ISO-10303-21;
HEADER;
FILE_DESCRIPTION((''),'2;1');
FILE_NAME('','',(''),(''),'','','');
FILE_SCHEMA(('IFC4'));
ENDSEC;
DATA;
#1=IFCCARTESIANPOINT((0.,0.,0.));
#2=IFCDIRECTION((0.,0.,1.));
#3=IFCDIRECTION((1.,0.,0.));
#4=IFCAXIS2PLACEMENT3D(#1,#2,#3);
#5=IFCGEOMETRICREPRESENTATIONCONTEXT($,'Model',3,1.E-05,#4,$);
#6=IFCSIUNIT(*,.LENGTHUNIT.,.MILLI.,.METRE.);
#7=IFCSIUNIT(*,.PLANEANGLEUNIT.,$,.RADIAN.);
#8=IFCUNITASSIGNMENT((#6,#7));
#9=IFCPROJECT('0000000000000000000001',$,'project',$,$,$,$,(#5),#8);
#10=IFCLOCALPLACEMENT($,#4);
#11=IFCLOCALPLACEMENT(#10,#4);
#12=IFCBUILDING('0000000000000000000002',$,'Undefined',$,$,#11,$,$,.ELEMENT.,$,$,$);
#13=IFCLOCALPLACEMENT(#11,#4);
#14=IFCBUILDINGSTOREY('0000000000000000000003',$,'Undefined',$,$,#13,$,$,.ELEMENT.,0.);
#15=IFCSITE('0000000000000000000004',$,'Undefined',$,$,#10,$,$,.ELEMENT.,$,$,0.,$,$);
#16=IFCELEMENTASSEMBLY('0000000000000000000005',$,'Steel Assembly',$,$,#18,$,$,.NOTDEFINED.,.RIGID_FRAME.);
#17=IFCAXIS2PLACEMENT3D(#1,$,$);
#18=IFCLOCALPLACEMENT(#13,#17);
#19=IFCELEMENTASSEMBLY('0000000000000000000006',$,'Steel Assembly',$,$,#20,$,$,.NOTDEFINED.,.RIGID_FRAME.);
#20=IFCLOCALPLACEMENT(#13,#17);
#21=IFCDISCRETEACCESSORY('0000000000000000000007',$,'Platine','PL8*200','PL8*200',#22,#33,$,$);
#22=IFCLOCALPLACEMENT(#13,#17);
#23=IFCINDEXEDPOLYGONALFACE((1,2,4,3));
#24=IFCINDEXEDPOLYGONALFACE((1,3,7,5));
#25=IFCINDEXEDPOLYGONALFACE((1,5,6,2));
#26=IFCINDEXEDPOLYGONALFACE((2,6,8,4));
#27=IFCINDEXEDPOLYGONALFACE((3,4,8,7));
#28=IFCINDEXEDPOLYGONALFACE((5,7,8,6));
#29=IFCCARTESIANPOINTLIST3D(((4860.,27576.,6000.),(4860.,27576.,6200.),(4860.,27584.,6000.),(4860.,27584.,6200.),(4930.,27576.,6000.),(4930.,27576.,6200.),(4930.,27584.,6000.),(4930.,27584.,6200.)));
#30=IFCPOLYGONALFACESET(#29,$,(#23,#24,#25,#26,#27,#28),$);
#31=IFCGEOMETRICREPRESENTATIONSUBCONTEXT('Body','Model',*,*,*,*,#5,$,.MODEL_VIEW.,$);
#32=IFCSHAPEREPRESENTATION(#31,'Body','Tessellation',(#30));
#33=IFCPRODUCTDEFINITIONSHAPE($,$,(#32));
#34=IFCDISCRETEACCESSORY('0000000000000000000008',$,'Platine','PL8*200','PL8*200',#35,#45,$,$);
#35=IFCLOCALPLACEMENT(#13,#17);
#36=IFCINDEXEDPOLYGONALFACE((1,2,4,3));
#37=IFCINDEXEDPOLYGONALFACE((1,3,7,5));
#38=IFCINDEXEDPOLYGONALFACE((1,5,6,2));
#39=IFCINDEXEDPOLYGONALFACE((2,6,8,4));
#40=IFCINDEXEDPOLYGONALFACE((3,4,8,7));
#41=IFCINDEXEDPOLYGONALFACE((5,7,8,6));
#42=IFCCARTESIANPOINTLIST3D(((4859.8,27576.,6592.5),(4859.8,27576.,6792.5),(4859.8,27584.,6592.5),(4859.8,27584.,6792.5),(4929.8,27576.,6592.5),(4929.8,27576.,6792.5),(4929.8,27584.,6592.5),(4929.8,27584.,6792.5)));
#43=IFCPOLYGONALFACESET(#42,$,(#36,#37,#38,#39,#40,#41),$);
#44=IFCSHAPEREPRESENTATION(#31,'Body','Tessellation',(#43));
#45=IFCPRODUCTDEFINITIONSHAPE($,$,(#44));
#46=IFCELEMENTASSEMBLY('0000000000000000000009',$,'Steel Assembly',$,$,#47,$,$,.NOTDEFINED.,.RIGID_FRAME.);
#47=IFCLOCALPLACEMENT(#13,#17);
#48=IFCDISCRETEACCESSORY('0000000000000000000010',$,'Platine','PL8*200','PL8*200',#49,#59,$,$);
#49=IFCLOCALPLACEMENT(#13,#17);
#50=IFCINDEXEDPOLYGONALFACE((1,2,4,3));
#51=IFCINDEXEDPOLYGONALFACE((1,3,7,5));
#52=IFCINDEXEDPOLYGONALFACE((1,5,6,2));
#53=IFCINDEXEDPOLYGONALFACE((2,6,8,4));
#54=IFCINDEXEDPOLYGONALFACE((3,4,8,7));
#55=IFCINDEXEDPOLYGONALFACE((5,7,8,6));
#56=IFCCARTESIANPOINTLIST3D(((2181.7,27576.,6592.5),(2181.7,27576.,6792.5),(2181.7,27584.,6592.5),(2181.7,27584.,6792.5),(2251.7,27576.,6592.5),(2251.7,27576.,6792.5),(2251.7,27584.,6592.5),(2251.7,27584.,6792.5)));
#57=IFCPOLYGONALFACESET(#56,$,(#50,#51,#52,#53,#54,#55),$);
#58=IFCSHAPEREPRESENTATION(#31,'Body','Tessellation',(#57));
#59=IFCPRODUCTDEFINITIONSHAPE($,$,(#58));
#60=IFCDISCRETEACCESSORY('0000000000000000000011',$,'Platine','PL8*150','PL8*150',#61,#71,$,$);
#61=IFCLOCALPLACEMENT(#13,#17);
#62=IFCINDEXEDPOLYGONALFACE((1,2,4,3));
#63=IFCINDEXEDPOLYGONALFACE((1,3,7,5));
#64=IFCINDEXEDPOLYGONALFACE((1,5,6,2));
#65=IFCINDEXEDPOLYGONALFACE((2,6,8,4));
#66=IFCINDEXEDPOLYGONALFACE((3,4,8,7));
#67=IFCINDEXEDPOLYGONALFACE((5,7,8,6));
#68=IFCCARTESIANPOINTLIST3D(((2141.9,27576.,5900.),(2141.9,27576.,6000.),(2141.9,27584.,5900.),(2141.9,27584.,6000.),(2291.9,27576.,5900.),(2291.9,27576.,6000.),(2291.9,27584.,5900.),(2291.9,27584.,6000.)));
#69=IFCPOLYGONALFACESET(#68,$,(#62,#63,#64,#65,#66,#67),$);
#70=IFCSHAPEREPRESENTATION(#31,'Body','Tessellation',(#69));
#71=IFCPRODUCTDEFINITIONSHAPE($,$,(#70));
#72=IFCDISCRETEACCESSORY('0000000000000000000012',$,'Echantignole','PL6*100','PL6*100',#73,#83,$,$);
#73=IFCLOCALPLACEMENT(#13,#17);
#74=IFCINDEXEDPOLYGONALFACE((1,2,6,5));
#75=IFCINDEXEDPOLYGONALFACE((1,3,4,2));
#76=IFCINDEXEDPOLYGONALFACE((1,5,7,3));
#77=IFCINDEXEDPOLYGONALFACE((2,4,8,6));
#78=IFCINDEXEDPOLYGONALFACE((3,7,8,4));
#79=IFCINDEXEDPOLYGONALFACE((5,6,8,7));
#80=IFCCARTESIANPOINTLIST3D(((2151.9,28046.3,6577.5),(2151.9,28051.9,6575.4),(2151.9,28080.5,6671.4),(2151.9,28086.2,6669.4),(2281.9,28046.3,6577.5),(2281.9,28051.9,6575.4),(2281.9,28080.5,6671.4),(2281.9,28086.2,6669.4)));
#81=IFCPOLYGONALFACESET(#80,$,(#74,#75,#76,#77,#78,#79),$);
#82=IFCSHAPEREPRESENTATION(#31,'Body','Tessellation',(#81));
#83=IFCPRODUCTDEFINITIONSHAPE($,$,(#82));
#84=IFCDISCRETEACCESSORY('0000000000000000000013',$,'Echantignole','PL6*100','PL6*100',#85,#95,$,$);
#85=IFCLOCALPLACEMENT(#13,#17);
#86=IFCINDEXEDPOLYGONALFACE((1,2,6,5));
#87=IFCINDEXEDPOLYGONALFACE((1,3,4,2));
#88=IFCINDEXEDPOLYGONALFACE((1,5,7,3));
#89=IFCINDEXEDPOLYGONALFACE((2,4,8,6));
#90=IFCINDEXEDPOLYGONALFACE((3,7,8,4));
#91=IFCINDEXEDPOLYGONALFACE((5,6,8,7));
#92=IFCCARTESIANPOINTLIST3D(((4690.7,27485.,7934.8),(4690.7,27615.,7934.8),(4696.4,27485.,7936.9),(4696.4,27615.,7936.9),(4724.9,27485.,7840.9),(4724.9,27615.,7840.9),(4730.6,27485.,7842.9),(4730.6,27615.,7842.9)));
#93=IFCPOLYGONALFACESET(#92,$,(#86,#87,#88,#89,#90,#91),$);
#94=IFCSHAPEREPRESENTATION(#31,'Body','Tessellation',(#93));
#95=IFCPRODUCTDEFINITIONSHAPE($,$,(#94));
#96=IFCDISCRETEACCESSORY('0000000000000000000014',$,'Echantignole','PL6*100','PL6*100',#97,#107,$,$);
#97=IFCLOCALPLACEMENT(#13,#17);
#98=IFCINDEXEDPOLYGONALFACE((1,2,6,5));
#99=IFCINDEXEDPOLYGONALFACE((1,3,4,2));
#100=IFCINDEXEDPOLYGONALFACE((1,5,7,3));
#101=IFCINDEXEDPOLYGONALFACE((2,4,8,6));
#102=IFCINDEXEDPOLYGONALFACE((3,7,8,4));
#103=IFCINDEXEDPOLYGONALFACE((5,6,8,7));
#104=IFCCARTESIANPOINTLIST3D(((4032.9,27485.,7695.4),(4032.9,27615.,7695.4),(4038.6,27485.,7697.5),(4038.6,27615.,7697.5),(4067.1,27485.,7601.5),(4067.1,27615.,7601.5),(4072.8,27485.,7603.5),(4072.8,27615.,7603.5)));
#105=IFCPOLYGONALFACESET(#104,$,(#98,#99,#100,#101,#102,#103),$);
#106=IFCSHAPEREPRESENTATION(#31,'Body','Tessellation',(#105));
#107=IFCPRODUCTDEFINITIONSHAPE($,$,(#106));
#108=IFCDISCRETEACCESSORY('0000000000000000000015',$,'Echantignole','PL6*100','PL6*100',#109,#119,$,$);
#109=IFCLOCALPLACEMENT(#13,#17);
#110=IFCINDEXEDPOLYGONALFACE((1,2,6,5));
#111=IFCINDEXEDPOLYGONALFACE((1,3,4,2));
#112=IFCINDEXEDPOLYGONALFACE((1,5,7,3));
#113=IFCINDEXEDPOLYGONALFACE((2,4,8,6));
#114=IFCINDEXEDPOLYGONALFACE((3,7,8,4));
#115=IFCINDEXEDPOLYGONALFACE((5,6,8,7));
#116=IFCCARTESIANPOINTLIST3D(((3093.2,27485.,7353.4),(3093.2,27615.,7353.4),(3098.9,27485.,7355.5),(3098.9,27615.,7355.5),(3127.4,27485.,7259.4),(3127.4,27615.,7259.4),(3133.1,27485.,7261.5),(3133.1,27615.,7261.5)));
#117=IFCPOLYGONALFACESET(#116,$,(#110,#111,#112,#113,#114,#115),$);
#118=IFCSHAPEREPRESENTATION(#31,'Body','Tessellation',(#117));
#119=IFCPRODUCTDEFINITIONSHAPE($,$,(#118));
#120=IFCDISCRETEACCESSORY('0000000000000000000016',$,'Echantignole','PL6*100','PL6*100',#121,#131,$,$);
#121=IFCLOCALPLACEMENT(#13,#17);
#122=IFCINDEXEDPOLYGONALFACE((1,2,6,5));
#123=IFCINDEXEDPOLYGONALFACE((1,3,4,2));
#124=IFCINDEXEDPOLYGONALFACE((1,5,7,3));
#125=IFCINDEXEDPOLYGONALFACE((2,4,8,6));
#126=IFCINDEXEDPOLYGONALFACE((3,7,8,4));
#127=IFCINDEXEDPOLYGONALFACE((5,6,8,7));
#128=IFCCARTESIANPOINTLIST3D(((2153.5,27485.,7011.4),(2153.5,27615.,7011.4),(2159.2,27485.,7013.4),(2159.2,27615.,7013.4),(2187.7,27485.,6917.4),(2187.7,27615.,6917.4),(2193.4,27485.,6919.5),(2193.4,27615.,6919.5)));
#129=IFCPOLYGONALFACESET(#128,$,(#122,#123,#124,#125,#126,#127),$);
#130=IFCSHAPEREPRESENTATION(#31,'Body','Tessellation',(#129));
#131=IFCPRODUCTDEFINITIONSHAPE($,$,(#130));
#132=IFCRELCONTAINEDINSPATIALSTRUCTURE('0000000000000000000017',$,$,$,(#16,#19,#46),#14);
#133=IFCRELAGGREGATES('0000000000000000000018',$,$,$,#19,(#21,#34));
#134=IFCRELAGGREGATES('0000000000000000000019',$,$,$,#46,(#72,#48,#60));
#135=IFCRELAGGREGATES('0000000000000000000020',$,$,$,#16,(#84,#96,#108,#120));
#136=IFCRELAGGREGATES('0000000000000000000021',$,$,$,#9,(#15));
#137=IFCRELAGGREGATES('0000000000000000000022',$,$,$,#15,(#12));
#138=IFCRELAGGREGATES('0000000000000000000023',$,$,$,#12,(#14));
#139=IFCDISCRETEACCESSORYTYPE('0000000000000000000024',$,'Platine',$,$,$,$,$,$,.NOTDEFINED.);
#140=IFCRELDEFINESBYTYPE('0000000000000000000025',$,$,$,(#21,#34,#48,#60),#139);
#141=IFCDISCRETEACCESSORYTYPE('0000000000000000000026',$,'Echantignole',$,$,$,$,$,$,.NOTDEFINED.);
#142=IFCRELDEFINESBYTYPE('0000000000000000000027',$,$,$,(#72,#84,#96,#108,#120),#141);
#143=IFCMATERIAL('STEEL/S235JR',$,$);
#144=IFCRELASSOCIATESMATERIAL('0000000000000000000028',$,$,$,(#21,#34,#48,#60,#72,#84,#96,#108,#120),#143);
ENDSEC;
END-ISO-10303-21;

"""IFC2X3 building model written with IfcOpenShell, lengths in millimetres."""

from ifc_helpers import new_model, si_unit, frame, origin_with_axes, place, context, subcontext, project, spatial, polyline, outline, extrude, material, type_object, element, aggregate, save


model = new_model("IFC2X3")

# Units and contexts
model_context = context("Model", 3, precision=1e-05, world=origin_with_axes())
body_context = subcontext(model_context, "Body", "Model", "MODEL_VIEW")
ifc_project = project(units=[si_unit("LENGTHUNIT", "METRE", prefix="MILLI"), si_unit("PLANEANGLEUNIT", "RADIAN")], contexts=[model_context])

# Site, building, storey
site_placement = place(None, origin_with_axes())
site = spatial("IfcSite", under=ifc_project, at=site_placement, Name="Undefined", CompositionType="ELEMENT", RefElevation=0.0)
building_placement = place(site_placement, origin_with_axes())
building = spatial("IfcBuilding", under=site, at=building_placement, Name="Undefined", CompositionType="ELEMENT")
storey_placement = place(building_placement, origin_with_axes())
storey = spatial("IfcBuildingStorey", under=building, at=storey_placement, Name="Undefined", CompositionType="ELEMENT", Elevation=0.0)

# Element assemblies, discrete accessories
assembly_1_placement = place(storey_placement, origin_with_axes())
assembly_1 = element("IfcElementAssembly", 1, at=assembly_1_placement, inside=storey, Name="Steel Assembly", AssemblyPlace="NOTDEFINED", PredefinedType="RIGID_FRAME")
ifc_material_1 = material(Name="STEEL/S235JR")
assembly_2_placement = place(storey_placement, origin_with_axes())
assembly_2 = element("IfcElementAssembly", 2, at=assembly_2_placement, inside=storey, Name="Steel Assembly", AssemblyPlace="NOTDEFINED", PredefinedType="RIGID_FRAME")
discrete_accessory_type_1 = type_object("IfcDiscreteAccessoryType", Name="Platine")
discrete_accessory_1_placement = place(assembly_2_placement, frame((4930.0, 27580.0, 6100.0), z_axis=(0.0, 1.0, 0.0), x_axis=(-1.0, 0.0, 0.0)))
discrete_accessory_1 = element("IfcDiscreteAccessory", 3, at=discrete_accessory_1_placement, type_object=discrete_accessory_type_1, material=ifc_material_1, Name="Platine", Description="PL8*200", ObjectType="PL8*200", context=body_context, shape_type="SweptSolid", body=[
    extrude(outline(polyline([(0.0, -100.0), (0.0, 100.0), (70.0, 100.0), (70.0, -100.0), (0.0, -100.0)])), frame((0.0, 0.0, -4.0), z_axis=(0.0, 0.0, 1.0), x_axis=(1.0, 0.0, 0.0)), (0.0, 0.0, 1.0), 8.0),
])
discrete_accessory_2_placement = place(assembly_2_placement, frame((4929.8, 27580.0, 6692.5), z_axis=(0.0, 1.0, 0.0), x_axis=(-1.0, 0.0, 0.0)))
discrete_accessory_2 = element("IfcDiscreteAccessory", 4, at=discrete_accessory_2_placement, type_object=discrete_accessory_type_1, material=ifc_material_1, Name="Platine", Description="PL8*200", ObjectType="PL8*200", context=body_context, shape_type="SweptSolid", body=[
    extrude(outline(polyline([(0.0, -100.0), (0.0, 100.0), (70.0, 100.0), (70.0, -100.0), (0.0, -100.0)])), frame((0.0, 0.0, -4.0), z_axis=(0.0, 0.0, 1.0), x_axis=(1.0, 0.0, 0.0)), (0.0, 0.0, 1.0), 8.0),
])
assembly_3_placement = place(storey_placement, origin_with_axes())
assembly_3 = element("IfcElementAssembly", 5, at=assembly_3_placement, inside=storey, Name="Steel Assembly", AssemblyPlace="NOTDEFINED", PredefinedType="RIGID_FRAME")
discrete_accessory_3_placement = place(assembly_3_placement, frame((2251.7, 27580.0, 6692.5), z_axis=(0.0, 1.0, 0.0), x_axis=(-1.0, 0.0, 0.0)))
discrete_accessory_3 = element("IfcDiscreteAccessory", 6, at=discrete_accessory_3_placement, type_object=discrete_accessory_type_1, material=ifc_material_1, Name="Platine", Description="PL8*200", ObjectType="PL8*200", context=body_context, shape_type="SweptSolid", body=[
    extrude(outline(polyline([(0.0, -100.0), (0.0, 100.0), (70.0, 100.0), (70.0, -100.0), (0.0, -100.0)])), frame((0.0, 0.0, -4.0), z_axis=(0.0, 0.0, 1.0), x_axis=(1.0, 0.0, 0.0)), (0.0, 0.0, 1.0), 8.0),
])
discrete_accessory_4_placement = place(assembly_3_placement, frame((2216.9, 27580.0, 5900.0), z_axis=(0.0, 1.0, 0.0), x_axis=(0.0, 0.0, 1.0)))
discrete_accessory_4 = element("IfcDiscreteAccessory", 7, at=discrete_accessory_4_placement, type_object=discrete_accessory_type_1, material=ifc_material_1, Name="Platine", Description="PL8*150", ObjectType="PL8*150", context=body_context, shape_type="SweptSolid", body=[
    extrude(outline(polyline([(0.0, 75.0), (100.0, 75.0), (100.0, -75.0), (0.0, -75.0), (0.0, 75.0)])), frame((0.0, 0.0, -4.0), z_axis=(0.0, 0.0, 1.0), x_axis=(1.0, 0.0, 0.0)), (0.0, 0.0, 1.0), 8.0),
])
discrete_accessory_type_2 = type_object("IfcDiscreteAccessoryType", Name="Echantignole")
discrete_accessory_5_placement = place(assembly_3_placement, frame((2281.9, 28066.2, 6623.4), z_axis=(0.0, 0.939693, -0.34202), x_axis=(-1.0, 0.0, 0.0)))
discrete_accessory_5 = element("IfcDiscreteAccessory", 8, at=discrete_accessory_5_placement, type_object=discrete_accessory_type_2, material=ifc_material_1, Name="Echantignole", Description="PL6*100", ObjectType="PL6*100", context=body_context, shape_type="SweptSolid", body=[
    extrude(outline(polyline([(0.0, -50.0), (0.0, 50.0), (130.0, 50.0), (130.0, -50.0), (0.0, -50.0)])), frame((0.0, 0.0, -3.0), z_axis=(0.0, 0.0, 1.0), x_axis=(1.0, 0.0, 0.0)), (0.0, 0.0, 1.0), 6.0),
])

# Discrete accessories
discrete_accessory_6_placement = place(assembly_1_placement, frame((4710.6, 27615.0, 7888.9), z_axis=(-0.939693, 0.0, -0.34202), x_axis=(0.0, -1.0, 0.0)))
discrete_accessory_6 = element("IfcDiscreteAccessory", 9, at=discrete_accessory_6_placement, type_object=discrete_accessory_type_2, material=ifc_material_1, Name="Echantignole", Description="PL6*100", ObjectType="PL6*100", context=body_context, shape_type="SweptSolid", body=[
    extrude(outline(polyline([(130.0, -50.0), (0.0, -50.0), (0.0, 50.0), (130.0, 50.0), (130.0, -50.0)])), frame((0.0, 0.0, -3.0), z_axis=(0.0, 0.0, 1.0), x_axis=(1.0, 0.0, 0.0)), (0.0, 0.0, 1.0), 6.0),
])
discrete_accessory_7_placement = place(assembly_1_placement, frame((4052.9, 27615.0, 7649.5), z_axis=(-0.939693, 0.0, -0.34202), x_axis=(0.0, -1.0, 0.0)))
discrete_accessory_7 = element("IfcDiscreteAccessory", 10, at=discrete_accessory_7_placement, type_object=discrete_accessory_type_2, material=ifc_material_1, Name="Echantignole", Description="PL6*100", ObjectType="PL6*100", context=body_context, shape_type="SweptSolid", body=[
    extrude(outline(polyline([(130.0, -50.0), (0.0, -50.0), (0.0, 50.0), (130.0, 50.0), (130.0, -50.0)])), frame((0.0, 0.0, -3.0), z_axis=(0.0, 0.0, 1.0), x_axis=(1.0, 0.0, 0.0)), (0.0, 0.0, 1.0), 6.0),
])
discrete_accessory_8_placement = place(assembly_1_placement, frame((3113.2, 27615.0, 7307.5), z_axis=(-0.939693, 0.0, -0.34202), x_axis=(0.0, -1.0, 0.0)))
discrete_accessory_8 = element("IfcDiscreteAccessory", 11, at=discrete_accessory_8_placement, type_object=discrete_accessory_type_2, material=ifc_material_1, Name="Echantignole", Description="PL6*100", ObjectType="PL6*100", context=body_context, shape_type="SweptSolid", body=[
    extrude(outline(polyline([(130.0, -50.0), (0.0, -50.0), (0.0, 50.0), (130.0, 50.0), (130.0, -50.0)])), frame((0.0, 0.0, -3.0), z_axis=(0.0, 0.0, 1.0), x_axis=(1.0, 0.0, 0.0)), (0.0, 0.0, 1.0), 6.0),
])
discrete_accessory_9_placement = place(assembly_1_placement, frame((2173.5, 27615.0, 6965.4), z_axis=(-0.939693, 0.0, -0.34202), x_axis=(0.0, -1.0, 0.0)))
discrete_accessory_9 = element("IfcDiscreteAccessory", 12, at=discrete_accessory_9_placement, type_object=discrete_accessory_type_2, material=ifc_material_1, Name="Echantignole", Description="PL6*100", ObjectType="PL6*100", context=body_context, shape_type="SweptSolid", body=[
    extrude(outline(polyline([(130.0, -50.0), (0.0, -50.0), (0.0, 50.0), (130.0, 50.0), (130.0, -50.0)])), frame((0.0, 0.0, -3.0), z_axis=(0.0, 0.0, 1.0), x_axis=(1.0, 0.0, 0.0)), (0.0, 0.0, 1.0), 6.0),
])

aggregate(assembly_2, [discrete_accessory_1, discrete_accessory_2])
aggregate(assembly_3, [discrete_accessory_5, discrete_accessory_3, discrete_accessory_4])

aggregate(assembly_1, [discrete_accessory_6, discrete_accessory_7, discrete_accessory_8, discrete_accessory_9])

save(model, "model.ifc")
